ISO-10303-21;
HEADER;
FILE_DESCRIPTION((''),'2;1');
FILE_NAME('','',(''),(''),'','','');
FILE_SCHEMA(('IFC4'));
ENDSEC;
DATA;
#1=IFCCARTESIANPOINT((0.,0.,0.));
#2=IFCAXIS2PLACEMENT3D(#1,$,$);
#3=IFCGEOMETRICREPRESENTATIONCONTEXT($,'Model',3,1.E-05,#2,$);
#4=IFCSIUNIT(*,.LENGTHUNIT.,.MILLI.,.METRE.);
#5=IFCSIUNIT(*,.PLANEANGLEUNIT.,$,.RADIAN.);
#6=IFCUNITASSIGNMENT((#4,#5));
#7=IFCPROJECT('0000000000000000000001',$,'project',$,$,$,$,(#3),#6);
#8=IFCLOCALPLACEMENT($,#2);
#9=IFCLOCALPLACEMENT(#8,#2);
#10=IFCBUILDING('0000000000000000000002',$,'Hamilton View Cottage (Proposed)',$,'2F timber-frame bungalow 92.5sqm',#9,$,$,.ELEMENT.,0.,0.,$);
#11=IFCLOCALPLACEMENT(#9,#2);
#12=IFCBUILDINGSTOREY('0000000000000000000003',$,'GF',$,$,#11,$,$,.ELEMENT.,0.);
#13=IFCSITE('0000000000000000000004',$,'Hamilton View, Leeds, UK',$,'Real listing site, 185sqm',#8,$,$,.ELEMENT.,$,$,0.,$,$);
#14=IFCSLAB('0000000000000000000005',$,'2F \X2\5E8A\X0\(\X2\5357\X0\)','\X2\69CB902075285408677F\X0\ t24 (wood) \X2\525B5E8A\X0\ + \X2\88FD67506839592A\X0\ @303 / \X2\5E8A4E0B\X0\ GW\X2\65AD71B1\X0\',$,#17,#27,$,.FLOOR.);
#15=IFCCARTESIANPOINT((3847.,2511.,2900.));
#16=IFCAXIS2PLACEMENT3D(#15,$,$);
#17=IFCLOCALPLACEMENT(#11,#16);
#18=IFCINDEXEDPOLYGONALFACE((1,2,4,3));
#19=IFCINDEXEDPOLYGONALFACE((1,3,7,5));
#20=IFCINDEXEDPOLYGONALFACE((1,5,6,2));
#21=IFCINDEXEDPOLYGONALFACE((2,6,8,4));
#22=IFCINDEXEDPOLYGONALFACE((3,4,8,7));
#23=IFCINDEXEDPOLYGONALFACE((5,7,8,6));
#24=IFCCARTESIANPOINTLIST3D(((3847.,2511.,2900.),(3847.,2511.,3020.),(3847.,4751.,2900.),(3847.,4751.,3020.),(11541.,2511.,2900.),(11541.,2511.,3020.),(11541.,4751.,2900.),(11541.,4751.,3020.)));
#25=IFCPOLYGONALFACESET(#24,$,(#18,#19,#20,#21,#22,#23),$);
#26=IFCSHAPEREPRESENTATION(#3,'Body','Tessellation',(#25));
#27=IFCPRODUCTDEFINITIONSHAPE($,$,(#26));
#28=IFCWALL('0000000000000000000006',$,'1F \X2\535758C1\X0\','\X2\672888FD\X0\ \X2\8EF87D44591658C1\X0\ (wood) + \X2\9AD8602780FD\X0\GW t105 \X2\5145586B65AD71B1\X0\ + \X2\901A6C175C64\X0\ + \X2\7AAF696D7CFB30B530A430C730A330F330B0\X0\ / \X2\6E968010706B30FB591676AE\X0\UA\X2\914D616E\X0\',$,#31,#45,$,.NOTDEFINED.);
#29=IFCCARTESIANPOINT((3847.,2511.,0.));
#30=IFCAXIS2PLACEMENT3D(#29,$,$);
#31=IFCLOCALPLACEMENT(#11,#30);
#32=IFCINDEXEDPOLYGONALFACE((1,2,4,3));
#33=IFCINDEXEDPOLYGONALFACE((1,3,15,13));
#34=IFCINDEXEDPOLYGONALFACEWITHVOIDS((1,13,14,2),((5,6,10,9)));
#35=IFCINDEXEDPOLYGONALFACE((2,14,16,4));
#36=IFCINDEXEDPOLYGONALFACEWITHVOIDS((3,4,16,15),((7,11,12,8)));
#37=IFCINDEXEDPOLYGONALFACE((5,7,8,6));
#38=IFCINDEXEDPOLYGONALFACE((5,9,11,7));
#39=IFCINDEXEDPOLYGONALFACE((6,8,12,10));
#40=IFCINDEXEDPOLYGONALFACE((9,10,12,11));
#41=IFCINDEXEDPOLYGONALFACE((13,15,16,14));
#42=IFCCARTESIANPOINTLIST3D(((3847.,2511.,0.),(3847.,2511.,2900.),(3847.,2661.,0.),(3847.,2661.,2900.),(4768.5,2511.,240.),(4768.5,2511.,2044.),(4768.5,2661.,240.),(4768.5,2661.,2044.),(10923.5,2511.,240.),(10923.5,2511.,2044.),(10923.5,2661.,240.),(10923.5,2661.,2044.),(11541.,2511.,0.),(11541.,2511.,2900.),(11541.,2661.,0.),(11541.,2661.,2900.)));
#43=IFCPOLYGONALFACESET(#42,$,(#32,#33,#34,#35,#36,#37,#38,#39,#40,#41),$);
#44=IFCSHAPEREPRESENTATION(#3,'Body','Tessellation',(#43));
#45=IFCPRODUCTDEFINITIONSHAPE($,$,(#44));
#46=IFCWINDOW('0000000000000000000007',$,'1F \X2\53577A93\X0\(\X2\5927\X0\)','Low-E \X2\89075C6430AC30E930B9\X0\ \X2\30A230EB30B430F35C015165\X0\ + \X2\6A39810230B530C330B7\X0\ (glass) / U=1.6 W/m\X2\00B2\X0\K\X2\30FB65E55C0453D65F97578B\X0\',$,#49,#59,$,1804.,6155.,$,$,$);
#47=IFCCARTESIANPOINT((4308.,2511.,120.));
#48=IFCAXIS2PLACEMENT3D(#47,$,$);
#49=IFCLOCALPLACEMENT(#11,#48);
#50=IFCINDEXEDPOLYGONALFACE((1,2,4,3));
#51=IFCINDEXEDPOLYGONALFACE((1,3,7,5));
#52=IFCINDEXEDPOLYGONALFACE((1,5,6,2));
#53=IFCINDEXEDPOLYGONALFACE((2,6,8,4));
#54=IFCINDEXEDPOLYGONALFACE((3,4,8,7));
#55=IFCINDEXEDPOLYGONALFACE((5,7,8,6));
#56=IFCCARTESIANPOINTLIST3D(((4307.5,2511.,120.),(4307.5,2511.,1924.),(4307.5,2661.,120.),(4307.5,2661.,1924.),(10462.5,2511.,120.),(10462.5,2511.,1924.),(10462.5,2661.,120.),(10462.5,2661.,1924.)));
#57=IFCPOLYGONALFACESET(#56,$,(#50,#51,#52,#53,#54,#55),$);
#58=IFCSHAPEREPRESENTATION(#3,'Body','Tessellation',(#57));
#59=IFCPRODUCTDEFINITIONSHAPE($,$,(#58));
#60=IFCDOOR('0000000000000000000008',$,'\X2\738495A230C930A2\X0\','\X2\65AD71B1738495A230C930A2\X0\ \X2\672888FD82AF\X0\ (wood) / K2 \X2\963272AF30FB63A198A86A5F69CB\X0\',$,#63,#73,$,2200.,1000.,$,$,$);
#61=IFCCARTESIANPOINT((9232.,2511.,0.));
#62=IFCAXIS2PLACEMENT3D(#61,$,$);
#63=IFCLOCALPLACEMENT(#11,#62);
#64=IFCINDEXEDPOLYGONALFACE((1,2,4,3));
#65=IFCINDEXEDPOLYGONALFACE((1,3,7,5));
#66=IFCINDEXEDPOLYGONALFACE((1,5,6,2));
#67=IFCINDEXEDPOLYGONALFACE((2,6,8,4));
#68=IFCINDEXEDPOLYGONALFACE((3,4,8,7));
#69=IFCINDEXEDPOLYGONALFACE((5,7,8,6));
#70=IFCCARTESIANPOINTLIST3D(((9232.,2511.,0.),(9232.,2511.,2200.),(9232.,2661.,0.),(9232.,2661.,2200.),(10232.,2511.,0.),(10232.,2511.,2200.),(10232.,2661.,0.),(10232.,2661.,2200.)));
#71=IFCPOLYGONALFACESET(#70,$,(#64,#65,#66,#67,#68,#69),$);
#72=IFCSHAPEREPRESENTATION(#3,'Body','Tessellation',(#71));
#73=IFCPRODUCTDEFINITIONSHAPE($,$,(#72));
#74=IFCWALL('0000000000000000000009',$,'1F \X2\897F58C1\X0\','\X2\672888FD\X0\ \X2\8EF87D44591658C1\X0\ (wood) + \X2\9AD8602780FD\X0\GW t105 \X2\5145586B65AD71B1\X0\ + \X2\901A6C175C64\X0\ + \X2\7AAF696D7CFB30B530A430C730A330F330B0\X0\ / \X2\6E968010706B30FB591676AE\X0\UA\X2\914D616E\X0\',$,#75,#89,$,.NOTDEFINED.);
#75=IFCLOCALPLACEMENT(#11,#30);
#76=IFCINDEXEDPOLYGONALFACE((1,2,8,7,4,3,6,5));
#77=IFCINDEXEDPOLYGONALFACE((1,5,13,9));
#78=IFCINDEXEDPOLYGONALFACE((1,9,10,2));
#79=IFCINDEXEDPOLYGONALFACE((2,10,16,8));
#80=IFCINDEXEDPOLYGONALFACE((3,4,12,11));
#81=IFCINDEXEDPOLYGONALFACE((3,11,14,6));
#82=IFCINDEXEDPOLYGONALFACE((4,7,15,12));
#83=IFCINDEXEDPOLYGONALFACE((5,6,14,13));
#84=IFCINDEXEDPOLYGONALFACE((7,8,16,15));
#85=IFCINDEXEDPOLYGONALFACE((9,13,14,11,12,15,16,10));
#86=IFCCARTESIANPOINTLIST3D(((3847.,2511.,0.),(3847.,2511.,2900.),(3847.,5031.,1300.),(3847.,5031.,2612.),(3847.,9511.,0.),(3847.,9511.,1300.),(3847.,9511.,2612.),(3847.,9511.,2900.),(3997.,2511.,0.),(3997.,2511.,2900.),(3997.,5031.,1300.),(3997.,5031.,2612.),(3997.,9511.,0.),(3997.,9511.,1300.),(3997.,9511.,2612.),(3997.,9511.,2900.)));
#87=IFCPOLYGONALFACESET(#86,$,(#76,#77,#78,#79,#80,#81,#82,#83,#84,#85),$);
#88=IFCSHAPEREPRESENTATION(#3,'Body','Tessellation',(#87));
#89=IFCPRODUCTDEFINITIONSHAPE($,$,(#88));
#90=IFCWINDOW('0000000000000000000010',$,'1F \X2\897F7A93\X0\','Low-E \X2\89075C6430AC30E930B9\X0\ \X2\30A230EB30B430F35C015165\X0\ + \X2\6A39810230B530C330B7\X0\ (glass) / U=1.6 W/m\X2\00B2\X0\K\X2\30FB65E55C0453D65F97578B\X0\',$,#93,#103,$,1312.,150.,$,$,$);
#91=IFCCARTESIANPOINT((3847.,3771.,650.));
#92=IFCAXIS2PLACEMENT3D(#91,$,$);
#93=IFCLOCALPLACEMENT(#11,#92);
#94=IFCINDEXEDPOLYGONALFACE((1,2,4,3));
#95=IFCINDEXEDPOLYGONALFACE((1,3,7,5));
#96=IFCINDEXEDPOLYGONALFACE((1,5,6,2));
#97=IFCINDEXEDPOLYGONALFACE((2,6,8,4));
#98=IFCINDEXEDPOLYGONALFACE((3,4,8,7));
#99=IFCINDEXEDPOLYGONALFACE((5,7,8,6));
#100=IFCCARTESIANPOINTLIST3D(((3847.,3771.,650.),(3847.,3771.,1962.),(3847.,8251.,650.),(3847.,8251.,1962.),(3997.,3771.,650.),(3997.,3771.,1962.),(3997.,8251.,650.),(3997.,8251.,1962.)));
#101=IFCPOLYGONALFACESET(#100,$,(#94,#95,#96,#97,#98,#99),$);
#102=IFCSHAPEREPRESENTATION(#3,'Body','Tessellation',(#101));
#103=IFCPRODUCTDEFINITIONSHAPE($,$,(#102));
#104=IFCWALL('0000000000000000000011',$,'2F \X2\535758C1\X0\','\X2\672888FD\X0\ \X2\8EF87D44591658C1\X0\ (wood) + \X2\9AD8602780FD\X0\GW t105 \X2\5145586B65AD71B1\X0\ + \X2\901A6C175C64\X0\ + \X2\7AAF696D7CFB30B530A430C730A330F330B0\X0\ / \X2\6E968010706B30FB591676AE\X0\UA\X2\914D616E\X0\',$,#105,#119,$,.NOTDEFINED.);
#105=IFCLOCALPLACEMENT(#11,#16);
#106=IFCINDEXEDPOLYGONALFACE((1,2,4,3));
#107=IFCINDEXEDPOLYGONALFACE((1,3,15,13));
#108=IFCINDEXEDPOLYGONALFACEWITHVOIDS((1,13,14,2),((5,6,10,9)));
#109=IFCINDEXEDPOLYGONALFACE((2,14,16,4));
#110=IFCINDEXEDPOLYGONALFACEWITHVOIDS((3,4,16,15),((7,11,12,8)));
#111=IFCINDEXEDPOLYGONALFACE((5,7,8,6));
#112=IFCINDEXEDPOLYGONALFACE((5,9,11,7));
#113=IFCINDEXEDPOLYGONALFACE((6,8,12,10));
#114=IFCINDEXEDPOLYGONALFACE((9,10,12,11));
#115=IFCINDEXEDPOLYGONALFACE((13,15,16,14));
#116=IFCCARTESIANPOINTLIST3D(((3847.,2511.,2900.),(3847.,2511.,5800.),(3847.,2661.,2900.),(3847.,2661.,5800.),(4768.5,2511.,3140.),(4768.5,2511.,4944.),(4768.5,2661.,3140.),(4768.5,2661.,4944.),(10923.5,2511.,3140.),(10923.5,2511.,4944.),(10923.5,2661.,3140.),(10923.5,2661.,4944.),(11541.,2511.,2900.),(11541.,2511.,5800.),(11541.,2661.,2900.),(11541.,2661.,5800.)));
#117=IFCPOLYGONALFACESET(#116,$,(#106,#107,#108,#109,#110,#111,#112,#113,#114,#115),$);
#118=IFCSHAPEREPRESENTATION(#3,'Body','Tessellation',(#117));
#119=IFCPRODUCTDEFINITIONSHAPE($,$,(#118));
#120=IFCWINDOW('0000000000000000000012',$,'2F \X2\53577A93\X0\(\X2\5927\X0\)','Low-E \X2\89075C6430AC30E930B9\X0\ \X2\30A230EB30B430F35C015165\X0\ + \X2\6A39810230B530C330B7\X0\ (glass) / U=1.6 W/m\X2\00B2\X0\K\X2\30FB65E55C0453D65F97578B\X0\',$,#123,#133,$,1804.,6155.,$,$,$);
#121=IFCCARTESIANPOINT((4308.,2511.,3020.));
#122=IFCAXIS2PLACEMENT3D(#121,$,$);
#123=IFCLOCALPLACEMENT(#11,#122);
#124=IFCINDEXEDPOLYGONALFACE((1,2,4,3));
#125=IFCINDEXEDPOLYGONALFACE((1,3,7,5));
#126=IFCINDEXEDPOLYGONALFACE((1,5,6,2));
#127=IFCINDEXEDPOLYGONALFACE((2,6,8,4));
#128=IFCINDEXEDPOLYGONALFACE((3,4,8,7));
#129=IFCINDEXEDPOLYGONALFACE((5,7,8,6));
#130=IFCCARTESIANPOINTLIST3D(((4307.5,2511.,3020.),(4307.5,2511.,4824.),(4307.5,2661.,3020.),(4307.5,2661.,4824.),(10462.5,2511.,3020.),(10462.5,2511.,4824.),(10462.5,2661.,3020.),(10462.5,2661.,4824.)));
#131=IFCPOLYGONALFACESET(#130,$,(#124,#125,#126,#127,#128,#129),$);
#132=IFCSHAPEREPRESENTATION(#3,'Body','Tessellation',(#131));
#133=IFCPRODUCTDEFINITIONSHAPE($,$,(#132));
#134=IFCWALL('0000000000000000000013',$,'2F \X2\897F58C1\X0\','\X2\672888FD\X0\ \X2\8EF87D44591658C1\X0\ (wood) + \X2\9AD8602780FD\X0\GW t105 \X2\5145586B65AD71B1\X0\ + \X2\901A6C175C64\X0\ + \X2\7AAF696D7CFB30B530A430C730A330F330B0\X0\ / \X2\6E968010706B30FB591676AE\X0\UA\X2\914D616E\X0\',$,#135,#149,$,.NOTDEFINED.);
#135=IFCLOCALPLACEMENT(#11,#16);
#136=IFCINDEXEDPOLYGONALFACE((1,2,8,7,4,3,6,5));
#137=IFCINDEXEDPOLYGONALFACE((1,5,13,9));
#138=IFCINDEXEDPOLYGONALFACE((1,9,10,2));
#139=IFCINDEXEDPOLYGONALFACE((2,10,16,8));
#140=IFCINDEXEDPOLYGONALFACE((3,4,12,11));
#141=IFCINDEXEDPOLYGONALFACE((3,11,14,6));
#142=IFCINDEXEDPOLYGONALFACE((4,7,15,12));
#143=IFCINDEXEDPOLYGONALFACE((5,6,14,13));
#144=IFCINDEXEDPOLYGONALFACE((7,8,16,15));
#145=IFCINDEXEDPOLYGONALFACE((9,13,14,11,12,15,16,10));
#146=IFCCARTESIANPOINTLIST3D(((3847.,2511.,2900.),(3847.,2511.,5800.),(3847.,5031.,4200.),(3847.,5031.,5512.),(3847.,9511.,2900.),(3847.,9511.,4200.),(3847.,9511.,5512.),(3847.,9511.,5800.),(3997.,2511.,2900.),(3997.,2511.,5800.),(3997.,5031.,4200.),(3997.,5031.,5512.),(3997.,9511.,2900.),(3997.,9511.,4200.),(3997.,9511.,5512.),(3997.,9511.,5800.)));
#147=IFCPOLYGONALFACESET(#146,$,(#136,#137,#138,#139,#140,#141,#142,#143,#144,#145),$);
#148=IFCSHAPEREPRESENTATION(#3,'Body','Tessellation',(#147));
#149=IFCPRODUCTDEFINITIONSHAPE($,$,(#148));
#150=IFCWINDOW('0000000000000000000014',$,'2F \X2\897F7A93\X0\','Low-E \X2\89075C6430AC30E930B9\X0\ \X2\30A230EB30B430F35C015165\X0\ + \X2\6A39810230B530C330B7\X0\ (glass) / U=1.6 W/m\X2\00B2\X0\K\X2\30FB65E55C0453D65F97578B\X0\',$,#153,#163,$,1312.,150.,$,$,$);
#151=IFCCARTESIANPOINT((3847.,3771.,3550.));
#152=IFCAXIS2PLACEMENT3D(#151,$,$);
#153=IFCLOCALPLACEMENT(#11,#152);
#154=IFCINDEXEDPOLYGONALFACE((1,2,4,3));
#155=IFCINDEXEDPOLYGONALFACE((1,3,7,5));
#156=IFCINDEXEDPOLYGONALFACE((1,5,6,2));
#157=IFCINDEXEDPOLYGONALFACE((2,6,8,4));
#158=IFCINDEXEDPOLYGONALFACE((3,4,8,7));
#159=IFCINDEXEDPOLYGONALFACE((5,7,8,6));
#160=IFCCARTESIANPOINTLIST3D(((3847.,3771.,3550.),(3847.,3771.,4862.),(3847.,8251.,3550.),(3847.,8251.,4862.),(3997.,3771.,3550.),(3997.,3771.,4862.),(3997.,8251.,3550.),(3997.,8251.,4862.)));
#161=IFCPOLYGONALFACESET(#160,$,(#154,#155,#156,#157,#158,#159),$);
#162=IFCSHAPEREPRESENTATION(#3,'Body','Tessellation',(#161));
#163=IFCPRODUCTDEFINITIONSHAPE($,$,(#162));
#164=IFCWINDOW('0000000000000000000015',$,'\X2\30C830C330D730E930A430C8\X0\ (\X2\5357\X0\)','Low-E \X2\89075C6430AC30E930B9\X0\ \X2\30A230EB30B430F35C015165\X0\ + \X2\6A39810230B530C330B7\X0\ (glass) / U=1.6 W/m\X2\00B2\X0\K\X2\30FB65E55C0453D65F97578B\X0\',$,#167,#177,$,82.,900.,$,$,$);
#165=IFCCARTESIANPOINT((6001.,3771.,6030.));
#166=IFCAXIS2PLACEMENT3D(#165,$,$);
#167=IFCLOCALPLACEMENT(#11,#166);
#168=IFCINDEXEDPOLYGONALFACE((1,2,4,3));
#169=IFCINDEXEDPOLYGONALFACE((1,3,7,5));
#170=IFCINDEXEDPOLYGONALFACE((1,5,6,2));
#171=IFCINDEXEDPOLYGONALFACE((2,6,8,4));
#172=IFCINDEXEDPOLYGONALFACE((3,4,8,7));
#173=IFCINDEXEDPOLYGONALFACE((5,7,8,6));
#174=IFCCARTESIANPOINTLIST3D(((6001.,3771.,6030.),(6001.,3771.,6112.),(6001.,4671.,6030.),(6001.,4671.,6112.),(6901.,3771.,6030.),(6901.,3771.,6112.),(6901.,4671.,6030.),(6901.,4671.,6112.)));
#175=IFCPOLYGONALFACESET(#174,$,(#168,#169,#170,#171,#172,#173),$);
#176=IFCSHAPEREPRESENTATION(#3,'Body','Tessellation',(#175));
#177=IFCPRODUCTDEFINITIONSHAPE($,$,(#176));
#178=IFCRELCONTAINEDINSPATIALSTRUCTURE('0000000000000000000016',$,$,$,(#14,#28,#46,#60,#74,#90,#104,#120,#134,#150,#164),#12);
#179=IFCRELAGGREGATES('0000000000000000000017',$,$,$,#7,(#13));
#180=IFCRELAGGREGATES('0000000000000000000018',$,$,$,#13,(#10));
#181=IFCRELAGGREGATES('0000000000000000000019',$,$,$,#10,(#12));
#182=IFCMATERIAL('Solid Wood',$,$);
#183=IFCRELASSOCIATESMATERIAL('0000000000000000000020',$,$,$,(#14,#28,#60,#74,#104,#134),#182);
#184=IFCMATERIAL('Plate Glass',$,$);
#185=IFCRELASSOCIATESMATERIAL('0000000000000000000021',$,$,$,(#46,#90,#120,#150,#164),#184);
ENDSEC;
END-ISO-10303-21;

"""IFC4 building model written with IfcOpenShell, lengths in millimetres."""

from ifc_helpers import new_model, si_unit, frame, frame_2d, origin, place, context, project, spatial, rectangle, extrude, material, element, fill, save


model = new_model("IFC4")

# Units and contexts
model_context = context("Model", 3, precision=1e-05, world=origin())
ifc_project = project(units=[si_unit("LENGTHUNIT", "METRE", prefix="MILLI"), si_unit("PLANEANGLEUNIT", "RADIAN")], contexts=[model_context])

# Site, building, storey
site_placement = place(None, origin())
site = spatial("IfcSite", under=ifc_project, at=site_placement, Name="Hamilton View, Leeds, UK", ObjectType="Real listing site, 185sqm", CompositionType="ELEMENT", RefElevation=0.0)
building_placement = place(site_placement, origin())
building = spatial("IfcBuilding", under=site, at=building_placement, Name="Hamilton View Cottage (Proposed)", ObjectType="2F timber-frame bungalow 92.5sqm", CompositionType="ELEMENT", ElevationOfRefHeight=0.0, ElevationOfTerrain=0.0)
storey_placement = place(building_placement, origin())
storey = spatial("IfcBuildingStorey", under=building, at=storey_placement, Name="GF", CompositionType="ELEMENT", Elevation=0.0)

# Slab
ifc_material_1 = material(Name="Solid Wood")
slab_1_placement = place(storey_placement, frame((3847.0, 2511.0, 2900.0)))
element("IfcSlab", 1, at=slab_1_placement, inside=storey, material=ifc_material_1, Name="2F 床(南)", Description="構造用合板 t24 (wood) 剛床 + 製材根太 @303 / 床下 GW断熱", PredefinedType="FLOOR", context=model_context, shape_type="SweptSolid", body=[
    extrude(rectangle(XDim=7694.0, YDim=2240.0, at=frame_2d((3847.0, 1120.0))), frame((3847.0, 2511.0, 2900.0)), (0.0, 0.0, 1.0), 120.0),
])

# Wall, openings, window, door
wall_1_placement = place(storey_placement, frame((3847.0, 2511.0, 0.0)))
wall_1 = element("IfcWall", 2, at=wall_1_placement, inside=storey, material=ifc_material_1, Name="1F 南壁", Description="木製 軸組外壁 (wood) + 高性能GW t105 充填断熱 + 通気層 + 窯業系サイディング / 準耐火・外皮UA配慮", PredefinedType="NOTDEFINED", context=model_context, shape_type="SweptSolid", body=[
    extrude(rectangle(XDim=7694.0, YDim=150.0, at=frame_2d((3847.0, 75.0))), frame((3847.0, 2511.0, 0.0)), (0.0, 0.0, 1.0), 2900.0),
])
opening_1_placement = place(storey_placement, frame((4308.0, 2511.0, 120.0)))
opening_1 = element("IfcOpeningElement", 3, at=opening_1_placement, cuts=wall_1, PredefinedType="NOTDEFINED", context=model_context, shape_type="SweptSolid", body=[
    extrude(rectangle(XDim=6155.0, YDim=150.0, at=frame_2d((3077.0, 75.0))), frame((4308.0, 2511.0, 120.0)), (0.0, 0.0, 1.0), 1804.0),
])
opening_2_placement = place(storey_placement, frame((9232.0, 2511.0, 0.0)))
opening_2 = element("IfcOpeningElement", 4, at=opening_2_placement, cuts=wall_1, PredefinedType="NOTDEFINED", context=model_context, shape_type="SweptSolid", body=[
    extrude(rectangle(XDim=1000.0, YDim=150.0, at=frame_2d((500.0, 75.0))), frame((9232.0, 2511.0, 0.0)), (0.0, 0.0, 1.0), 2200.0),
])
ifc_material_2 = material(Name="Plate Glass")
window_1_placement = place(storey_placement, frame((4308.0, 2511.0, 120.0)))
window_1 = element("IfcWindow", 5, at=window_1_placement, inside=storey, material=ifc_material_2, Name="1F 南窓(大)", Description="Low-E 複層ガラス アルゴン封入 + 樹脂サッシ (glass) / U=1.6 W/m²K・日射取得型", OverallHeight=1804.0, OverallWidth=6155.0, context=model_context, shape_type="SweptSolid", body=[
    extrude(rectangle(XDim=6155.0, YDim=150.0, at=frame_2d((3077.0, 75.0))), frame((4308.0, 2511.0, 120.0)), (0.0, 0.0, 1.0), 1804.0),
])
fill(opening_1, window_1)
door_placement = place(storey_placement, frame((9232.0, 2511.0, 0.0)))
door = element("IfcDoor", 6, at=door_placement, inside=storey, material=ifc_material_1, Name="玄関ドア", Description="断熱玄関ドア 木製芯 (wood) / K2 防犯・採風機構", OverallHeight=2200.0, OverallWidth=1000.0, context=model_context, shape_type="SweptSolid", body=[
    extrude(rectangle(XDim=1000.0, YDim=150.0, at=frame_2d((500.0, 75.0))), frame((9232.0, 2511.0, 0.0)), (0.0, 0.0, 1.0), 2200.0),
])
fill(opening_2, door)

# Walls, openings, windows
wall_2_placement = place(storey_placement, frame((3847.0, 2511.0, 0.0)))
wall_2 = element("IfcWall", 7, at=wall_2_placement, inside=storey, material=ifc_material_1, Name="1F 西壁", Description="木製 軸組外壁 (wood) + 高性能GW t105 充填断熱 + 通気層 + 窯業系サイディング / 準耐火・外皮UA配慮", PredefinedType="NOTDEFINED", context=model_context, shape_type="SweptSolid", body=[
    extrude(rectangle(XDim=150.0, YDim=7000.0, at=frame_2d((75.0, 3500.0))), frame((3847.0, 2511.0, 0.0)), (0.0, 0.0, 1.0), 2900.0),
])
opening_3_placement = place(storey_placement, frame((3847.0, 3771.0, 650.0)))
opening_3 = element("IfcOpeningElement", 8, at=opening_3_placement, cuts=wall_2, PredefinedType="NOTDEFINED", context=model_context, shape_type="SweptSolid", body=[
    extrude(rectangle(XDim=150.0, YDim=4480.0, at=frame_2d((75.0, 2240.0))), frame((3847.0, 3771.0, 650.0)), (0.0, 0.0, 1.0), 1312.0),
])
window_2_placement = place(storey_placement, frame((3847.0, 3771.0, 650.0)))
window_2 = element("IfcWindow", 9, at=window_2_placement, inside=storey, material=ifc_material_2, Name="1F 西窓", Description="Low-E 複層ガラス アルゴン封入 + 樹脂サッシ (glass) / U=1.6 W/m²K・日射取得型", OverallHeight=1312.0, OverallWidth=150.0, context=model_context, shape_type="SweptSolid", body=[
    extrude(rectangle(XDim=150.0, YDim=4480.0, at=frame_2d((75.0, 2240.0))), frame((3847.0, 3771.0, 650.0)), (0.0, 0.0, 1.0), 1312.0),
])
fill(opening_3, window_2)
wall_3_placement = place(storey_placement, frame((3847.0, 2511.0, 2900.0)))
wall_3 = element("IfcWall", 10, at=wall_3_placement, inside=storey, material=ifc_material_1, Name="2F 南壁", Description="木製 軸組外壁 (wood) + 高性能GW t105 充填断熱 + 通気層 + 窯業系サイディング / 準耐火・外皮UA配慮", PredefinedType="NOTDEFINED", context=model_context, shape_type="SweptSolid", body=[
    extrude(rectangle(XDim=7694.0, YDim=150.0, at=frame_2d((3847.0, 75.0))), frame((3847.0, 2511.0, 2900.0)), (0.0, 0.0, 1.0), 2900.0),
])
opening_4_placement = place(storey_placement, frame((4308.0, 2511.0, 3020.0)))
opening_4 = element("IfcOpeningElement", 11, at=opening_4_placement, cuts=wall_3, PredefinedType="NOTDEFINED", context=model_context, shape_type="SweptSolid", body=[
    extrude(rectangle(XDim=6155.0, YDim=150.0, at=frame_2d((3077.0, 75.0))), frame((4308.0, 2511.0, 3020.0)), (0.0, 0.0, 1.0), 1804.0),
])
window_3_placement = place(storey_placement, frame((4308.0, 2511.0, 3020.0)))
window_3 = element("IfcWindow", 12, at=window_3_placement, inside=storey, material=ifc_material_2, Name="2F 南窓(大)", Description="Low-E 複層ガラス アルゴン封入 + 樹脂サッシ (glass) / U=1.6 W/m²K・日射取得型", OverallHeight=1804.0, OverallWidth=6155.0, context=model_context, shape_type="SweptSolid", body=[
    extrude(rectangle(XDim=6155.0, YDim=150.0, at=frame_2d((3077.0, 75.0))), frame((4308.0, 2511.0, 3020.0)), (0.0, 0.0, 1.0), 1804.0),
])
fill(opening_4, window_3)
wall_4_placement = place(storey_placement, frame((3847.0, 2511.0, 2900.0)))
wall_4 = element("IfcWall", 13, at=wall_4_placement, inside=storey, material=ifc_material_1, Name="2F 西壁", Description="木製 軸組外壁 (wood) + 高性能GW t105 充填断熱 + 通気層 + 窯業系サイディング / 準耐火・外皮UA配慮", PredefinedType="NOTDEFINED", context=model_context, shape_type="SweptSolid", body=[
    extrude(rectangle(XDim=150.0, YDim=7000.0, at=frame_2d((75.0, 3500.0))), frame((3847.0, 2511.0, 2900.0)), (0.0, 0.0, 1.0), 2900.0),
])
opening_5_placement = place(storey_placement, frame((3847.0, 3771.0, 3550.0)))
opening_5 = element("IfcOpeningElement", 14, at=opening_5_placement, cuts=wall_4, PredefinedType="NOTDEFINED", context=model_context, shape_type="SweptSolid", body=[
    extrude(rectangle(XDim=150.0, YDim=4480.0, at=frame_2d((75.0, 2240.0))), frame((3847.0, 3771.0, 3550.0)), (0.0, 0.0, 1.0), 1312.0),
])
window_4_placement = place(storey_placement, frame((3847.0, 3771.0, 3550.0)))
window_4 = element("IfcWindow", 15, at=window_4_placement, inside=storey, material=ifc_material_2, Name="2F 西窓", Description="Low-E 複層ガラス アルゴン封入 + 樹脂サッシ (glass) / U=1.6 W/m²K・日射取得型", OverallHeight=1312.0, OverallWidth=150.0, context=model_context, shape_type="SweptSolid", body=[
    extrude(rectangle(XDim=150.0, YDim=4480.0, at=frame_2d((75.0, 2240.0))), frame((3847.0, 3771.0, 3550.0)), (0.0, 0.0, 1.0), 1312.0),
])
fill(opening_5, window_4)

# Window
window_5_placement = place(storey_placement, frame((6001.0, 3771.0, 6030.0)))
element("IfcWindow", 16, at=window_5_placement, inside=storey, material=ifc_material_2, Name="トップライト (南)", Description="Low-E 複層ガラス アルゴン封入 + 樹脂サッシ (glass) / U=1.6 W/m²K・日射取得型", OverallHeight=82.0, OverallWidth=900.0, context=model_context, shape_type="SweptSolid", body=[
    extrude(rectangle(XDim=900.0, YDim=900.0, at=frame_2d((450.0, 450.0))), frame((6001.0, 3771.0, 6030.0)), (0.0, 0.0, 1.0), 82.0),
])

save(model, "model.ifc")
